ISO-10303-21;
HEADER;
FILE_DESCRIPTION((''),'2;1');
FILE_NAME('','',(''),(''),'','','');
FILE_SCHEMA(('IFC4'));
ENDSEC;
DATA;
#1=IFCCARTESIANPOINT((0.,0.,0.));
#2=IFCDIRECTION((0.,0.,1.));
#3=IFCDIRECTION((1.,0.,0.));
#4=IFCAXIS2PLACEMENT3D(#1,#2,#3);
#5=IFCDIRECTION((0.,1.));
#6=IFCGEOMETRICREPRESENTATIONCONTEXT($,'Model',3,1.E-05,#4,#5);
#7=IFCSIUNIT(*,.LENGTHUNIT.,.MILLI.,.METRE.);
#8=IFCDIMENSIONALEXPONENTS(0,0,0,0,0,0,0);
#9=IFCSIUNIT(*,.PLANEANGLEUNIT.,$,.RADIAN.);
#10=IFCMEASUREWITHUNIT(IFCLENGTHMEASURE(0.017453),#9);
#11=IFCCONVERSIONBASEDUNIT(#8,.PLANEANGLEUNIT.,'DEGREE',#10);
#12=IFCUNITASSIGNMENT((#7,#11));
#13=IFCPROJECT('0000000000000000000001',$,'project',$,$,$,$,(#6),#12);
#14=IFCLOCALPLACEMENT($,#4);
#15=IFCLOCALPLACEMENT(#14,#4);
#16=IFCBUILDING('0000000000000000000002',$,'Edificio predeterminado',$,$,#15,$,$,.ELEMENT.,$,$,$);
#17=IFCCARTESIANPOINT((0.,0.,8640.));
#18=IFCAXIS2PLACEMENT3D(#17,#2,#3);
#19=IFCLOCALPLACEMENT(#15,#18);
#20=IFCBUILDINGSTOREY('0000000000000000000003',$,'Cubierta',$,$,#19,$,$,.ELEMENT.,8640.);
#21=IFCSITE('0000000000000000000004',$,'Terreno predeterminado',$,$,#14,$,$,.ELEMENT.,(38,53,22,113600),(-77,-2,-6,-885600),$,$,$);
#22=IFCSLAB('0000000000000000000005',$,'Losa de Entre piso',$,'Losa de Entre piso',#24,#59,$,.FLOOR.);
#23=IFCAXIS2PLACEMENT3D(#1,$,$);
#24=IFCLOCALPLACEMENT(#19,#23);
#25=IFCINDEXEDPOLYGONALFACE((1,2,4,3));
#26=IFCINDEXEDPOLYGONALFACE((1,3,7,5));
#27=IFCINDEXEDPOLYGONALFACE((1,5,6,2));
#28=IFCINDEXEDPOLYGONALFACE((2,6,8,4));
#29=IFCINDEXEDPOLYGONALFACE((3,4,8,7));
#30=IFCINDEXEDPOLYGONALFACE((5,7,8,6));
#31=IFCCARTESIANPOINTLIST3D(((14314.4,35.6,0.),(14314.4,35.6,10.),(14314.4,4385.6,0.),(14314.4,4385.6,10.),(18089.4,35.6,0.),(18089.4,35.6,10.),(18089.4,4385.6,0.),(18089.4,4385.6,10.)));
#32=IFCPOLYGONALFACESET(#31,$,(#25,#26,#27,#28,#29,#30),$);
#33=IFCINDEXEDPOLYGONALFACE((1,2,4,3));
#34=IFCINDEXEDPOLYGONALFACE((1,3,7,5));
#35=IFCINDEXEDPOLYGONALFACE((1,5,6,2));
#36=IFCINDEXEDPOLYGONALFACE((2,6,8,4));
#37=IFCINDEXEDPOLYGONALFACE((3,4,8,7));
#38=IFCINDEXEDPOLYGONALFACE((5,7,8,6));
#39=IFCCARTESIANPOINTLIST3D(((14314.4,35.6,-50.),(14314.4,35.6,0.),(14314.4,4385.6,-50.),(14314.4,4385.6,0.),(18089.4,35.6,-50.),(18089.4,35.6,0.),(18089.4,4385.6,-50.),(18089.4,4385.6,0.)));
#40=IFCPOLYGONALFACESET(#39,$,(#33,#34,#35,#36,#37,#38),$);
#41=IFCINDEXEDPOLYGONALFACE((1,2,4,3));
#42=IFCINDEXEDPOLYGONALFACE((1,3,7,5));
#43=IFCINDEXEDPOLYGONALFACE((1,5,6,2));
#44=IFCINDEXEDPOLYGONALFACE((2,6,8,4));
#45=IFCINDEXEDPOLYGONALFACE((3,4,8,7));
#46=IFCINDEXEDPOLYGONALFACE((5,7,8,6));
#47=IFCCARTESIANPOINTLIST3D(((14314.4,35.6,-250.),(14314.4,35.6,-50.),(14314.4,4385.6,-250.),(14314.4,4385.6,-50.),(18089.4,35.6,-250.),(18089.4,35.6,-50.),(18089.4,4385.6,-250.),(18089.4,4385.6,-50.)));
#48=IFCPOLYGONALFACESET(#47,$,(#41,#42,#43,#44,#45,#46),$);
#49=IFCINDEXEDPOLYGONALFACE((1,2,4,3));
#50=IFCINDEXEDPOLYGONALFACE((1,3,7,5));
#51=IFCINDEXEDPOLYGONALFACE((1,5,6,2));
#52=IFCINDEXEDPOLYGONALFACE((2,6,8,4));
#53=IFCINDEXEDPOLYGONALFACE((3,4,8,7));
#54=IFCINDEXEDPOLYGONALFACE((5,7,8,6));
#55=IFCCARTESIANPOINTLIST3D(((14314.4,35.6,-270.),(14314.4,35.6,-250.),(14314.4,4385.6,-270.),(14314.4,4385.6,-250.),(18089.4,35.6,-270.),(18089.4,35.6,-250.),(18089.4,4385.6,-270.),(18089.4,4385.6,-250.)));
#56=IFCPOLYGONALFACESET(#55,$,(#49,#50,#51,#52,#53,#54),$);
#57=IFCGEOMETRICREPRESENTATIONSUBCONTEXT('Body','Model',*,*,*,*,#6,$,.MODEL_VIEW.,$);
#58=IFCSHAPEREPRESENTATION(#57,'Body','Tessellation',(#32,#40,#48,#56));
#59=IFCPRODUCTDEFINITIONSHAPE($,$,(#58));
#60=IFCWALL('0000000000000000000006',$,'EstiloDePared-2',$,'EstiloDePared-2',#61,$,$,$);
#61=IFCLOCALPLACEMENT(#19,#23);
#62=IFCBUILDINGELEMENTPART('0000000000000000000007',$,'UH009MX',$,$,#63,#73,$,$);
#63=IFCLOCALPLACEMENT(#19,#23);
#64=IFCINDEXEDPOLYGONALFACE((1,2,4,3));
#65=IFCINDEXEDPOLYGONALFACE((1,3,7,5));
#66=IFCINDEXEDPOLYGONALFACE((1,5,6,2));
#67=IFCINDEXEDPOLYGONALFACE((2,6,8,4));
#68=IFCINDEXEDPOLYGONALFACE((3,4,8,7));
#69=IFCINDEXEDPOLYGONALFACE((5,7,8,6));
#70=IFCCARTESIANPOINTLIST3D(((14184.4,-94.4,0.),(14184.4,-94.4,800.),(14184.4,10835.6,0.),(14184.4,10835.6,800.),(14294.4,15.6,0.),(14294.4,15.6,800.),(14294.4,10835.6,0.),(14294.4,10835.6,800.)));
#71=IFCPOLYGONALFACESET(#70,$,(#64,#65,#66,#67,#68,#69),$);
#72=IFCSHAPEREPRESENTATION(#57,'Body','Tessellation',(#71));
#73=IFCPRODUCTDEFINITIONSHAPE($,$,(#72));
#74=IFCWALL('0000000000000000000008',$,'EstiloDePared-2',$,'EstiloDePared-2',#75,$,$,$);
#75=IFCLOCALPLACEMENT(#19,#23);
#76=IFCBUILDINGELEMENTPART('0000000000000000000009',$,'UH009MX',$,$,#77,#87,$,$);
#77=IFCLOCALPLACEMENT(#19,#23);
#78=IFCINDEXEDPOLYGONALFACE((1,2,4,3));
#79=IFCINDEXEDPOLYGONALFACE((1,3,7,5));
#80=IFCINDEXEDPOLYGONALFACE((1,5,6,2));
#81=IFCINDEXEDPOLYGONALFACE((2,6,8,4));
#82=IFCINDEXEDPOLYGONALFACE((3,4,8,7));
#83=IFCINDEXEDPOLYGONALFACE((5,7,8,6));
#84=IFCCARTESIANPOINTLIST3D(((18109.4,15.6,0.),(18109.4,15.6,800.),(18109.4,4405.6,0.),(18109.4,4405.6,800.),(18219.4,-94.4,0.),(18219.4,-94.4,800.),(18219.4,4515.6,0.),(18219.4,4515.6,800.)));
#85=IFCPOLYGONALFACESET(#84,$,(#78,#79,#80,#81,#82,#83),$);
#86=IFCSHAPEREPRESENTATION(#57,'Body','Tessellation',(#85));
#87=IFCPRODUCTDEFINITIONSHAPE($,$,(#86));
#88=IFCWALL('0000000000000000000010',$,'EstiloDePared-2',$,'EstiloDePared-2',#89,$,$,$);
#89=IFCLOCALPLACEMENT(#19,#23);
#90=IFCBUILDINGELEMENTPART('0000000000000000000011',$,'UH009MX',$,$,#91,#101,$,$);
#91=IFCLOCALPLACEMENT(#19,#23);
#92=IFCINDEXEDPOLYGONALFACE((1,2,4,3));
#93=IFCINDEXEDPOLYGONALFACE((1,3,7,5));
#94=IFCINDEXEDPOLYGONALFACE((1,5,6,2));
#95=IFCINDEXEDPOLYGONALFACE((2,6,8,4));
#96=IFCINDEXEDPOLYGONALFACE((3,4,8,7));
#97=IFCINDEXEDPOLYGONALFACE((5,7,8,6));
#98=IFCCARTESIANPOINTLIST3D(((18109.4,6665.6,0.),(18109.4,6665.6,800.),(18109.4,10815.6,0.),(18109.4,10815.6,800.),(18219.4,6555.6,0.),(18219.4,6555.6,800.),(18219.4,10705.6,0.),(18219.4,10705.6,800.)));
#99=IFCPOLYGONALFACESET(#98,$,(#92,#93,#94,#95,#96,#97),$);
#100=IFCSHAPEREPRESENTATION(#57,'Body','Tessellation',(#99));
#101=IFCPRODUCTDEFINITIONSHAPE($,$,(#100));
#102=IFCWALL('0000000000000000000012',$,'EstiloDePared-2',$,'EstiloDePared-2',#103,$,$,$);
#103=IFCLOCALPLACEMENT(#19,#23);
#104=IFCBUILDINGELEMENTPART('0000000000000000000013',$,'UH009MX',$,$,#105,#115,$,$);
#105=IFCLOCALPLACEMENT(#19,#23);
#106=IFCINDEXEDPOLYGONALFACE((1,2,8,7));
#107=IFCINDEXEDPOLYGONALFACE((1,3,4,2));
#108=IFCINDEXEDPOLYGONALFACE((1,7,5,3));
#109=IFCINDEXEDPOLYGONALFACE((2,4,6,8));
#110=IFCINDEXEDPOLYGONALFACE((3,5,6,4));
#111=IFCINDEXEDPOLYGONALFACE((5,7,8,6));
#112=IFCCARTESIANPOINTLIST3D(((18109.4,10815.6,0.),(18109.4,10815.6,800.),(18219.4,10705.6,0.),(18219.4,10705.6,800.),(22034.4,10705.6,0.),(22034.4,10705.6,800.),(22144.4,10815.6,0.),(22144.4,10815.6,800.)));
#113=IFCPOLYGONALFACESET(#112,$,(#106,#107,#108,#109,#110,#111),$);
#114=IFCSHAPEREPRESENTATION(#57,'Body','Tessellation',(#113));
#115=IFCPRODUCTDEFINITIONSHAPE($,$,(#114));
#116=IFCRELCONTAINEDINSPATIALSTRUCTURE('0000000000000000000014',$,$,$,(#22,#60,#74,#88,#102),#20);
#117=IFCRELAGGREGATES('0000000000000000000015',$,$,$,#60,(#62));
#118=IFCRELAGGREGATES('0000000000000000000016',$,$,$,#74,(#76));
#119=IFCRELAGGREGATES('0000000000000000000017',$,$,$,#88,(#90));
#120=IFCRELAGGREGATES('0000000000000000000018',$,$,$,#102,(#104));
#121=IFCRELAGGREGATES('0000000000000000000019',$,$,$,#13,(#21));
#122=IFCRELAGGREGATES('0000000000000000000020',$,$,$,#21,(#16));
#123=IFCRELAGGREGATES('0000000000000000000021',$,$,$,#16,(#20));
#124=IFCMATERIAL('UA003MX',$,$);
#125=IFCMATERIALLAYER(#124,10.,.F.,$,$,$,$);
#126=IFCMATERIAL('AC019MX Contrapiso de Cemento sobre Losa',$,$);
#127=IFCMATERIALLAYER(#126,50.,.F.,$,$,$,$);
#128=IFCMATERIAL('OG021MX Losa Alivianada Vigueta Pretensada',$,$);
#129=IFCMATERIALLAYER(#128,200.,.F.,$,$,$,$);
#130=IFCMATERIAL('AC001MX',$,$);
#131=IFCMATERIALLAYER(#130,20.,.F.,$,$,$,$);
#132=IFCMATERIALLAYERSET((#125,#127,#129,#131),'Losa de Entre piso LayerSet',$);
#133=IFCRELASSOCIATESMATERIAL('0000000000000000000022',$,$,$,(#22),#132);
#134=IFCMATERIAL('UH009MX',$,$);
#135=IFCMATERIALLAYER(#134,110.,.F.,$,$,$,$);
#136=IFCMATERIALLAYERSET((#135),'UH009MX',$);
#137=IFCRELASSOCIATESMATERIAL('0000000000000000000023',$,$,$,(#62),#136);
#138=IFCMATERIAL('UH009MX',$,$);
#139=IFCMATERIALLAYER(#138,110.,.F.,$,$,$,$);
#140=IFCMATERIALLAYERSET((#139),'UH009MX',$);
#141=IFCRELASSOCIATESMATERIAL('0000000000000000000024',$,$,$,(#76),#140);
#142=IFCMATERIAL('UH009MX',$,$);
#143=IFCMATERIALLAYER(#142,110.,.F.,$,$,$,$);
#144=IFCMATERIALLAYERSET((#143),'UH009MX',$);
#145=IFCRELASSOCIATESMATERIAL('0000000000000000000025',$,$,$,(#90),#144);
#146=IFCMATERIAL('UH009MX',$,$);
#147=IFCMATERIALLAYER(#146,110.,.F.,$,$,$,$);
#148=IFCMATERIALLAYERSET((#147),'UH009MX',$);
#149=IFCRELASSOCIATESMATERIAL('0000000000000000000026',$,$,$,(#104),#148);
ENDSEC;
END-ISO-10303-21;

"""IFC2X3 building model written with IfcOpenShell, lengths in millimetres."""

from ifc_helpers import new_model, entity, si_unit, converted_unit, direction, frame, origin_with_axes, place, context, subcontext, project, spatial, polyline, outline, extrude, material, layer, layer_set, layer_usage, element, aggregate, save


model = new_model("IFC2X3")

# Units and contexts
model_context = context("Model", 3, precision=1e-05, world=origin_with_axes(), true_north=direction((0.0, 1.0)))
body_context = subcontext(model_context, "Body", "Model", "MODEL_VIEW")
ifc_project = project(units=[si_unit("LENGTHUNIT", "METRE", prefix="MILLI"), converted_unit("PLANEANGLEUNIT", "DEGREE", entity("IfcLengthMeasure", 0.017453), si_unit("PLANEANGLEUNIT", "RADIAN"), dimensions=[0, 0, 0, 0, 0, 0, 0])], contexts=[model_context])

# Site, building, storey
site_placement = place(None, origin_with_axes())
site = spatial("IfcSite", under=ifc_project, at=site_placement, Name="Terreno predeterminado", CompositionType="ELEMENT", RefLatitude=(38, 53, 22, 113600), RefLongitude=(-77, -2, -6, -885600))
building_placement = place(site_placement, origin_with_axes())
building = spatial("IfcBuilding", under=site, at=building_placement, Name="Edificio predeterminado", CompositionType="ELEMENT")
storey_placement = place(building_placement, frame((0.0, 0.0, 8640.0), z_axis=(0.0, 0.0, 1.0), x_axis=(1.0, 0.0, 0.0)))
storey = spatial("IfcBuildingStorey", under=building, at=storey_placement, Name="Cubierta", CompositionType="ELEMENT", Elevation=8640.0)

# Slab
ifc_material_1 = material(Name="UA003MX")
ifc_layer_1 = layer(ifc_material_1, 10.0, ventilated=False)
ifc_material_2 = material(Name="AC019MX Contrapiso de Cemento sobre Losa")
ifc_layer_2 = layer(ifc_material_2, 50.0, ventilated=False)
ifc_material_3 = material(Name="OG021MX Losa Alivianada Vigueta Pretensada")
ifc_layer_3 = layer(ifc_material_3, 200.0, ventilated=False)
ifc_material_4 = material(Name="AC001MX")
ifc_layer_4 = layer(ifc_material_4, 20.0, ventilated=False)
ifc_layer_set_1 = layer_set([ifc_layer_1, ifc_layer_2, ifc_layer_3, ifc_layer_4], Name="Losa de Entre piso LayerSet")
ifc_layer_usage_1 = layer_usage(ifc_layer_set_1, "AXIS3", "NEGATIVE", 0.0)
slab_1_placement = place(storey_placement, frame((0.0, 0.0, -8640.0), z_axis=(0.0, 0.0, 1.0), x_axis=(1.0, 0.0, 0.0)))
element("IfcSlab", 1, at=slab_1_placement, inside=storey, material=ifc_layer_usage_1, Name="Losa de Entre piso", ObjectType="Losa de Entre piso", PredefinedType="FLOOR", context=body_context, shape_type="SweptSolid", body=[
    extrude(outline(polyline([(0.0, 4350.0), (3775.0, 4350.0), (3775.0, 0.0), (0.0, 0.0), (0.0, 4350.0)])), frame((18089.4, 35.6, 8640.0), z_axis=(0.0, 0.0, -1.0), x_axis=(-1.0, 0.0, 0.0)), (0.0, 0.0, -1.0), 10.0),
    extrude(outline(polyline([(0.0, 4350.0), (3775.0, 4350.0), (3775.0, 0.0), (0.0, 0.0), (0.0, 4350.0)])), frame((18089.4, 35.6, 8590.0), z_axis=(0.0, 0.0, -1.0), x_axis=(-1.0, 0.0, 0.0)), (0.0, 0.0, -1.0), 50.0),
    extrude(outline(polyline([(0.0, 4350.0), (3775.0, 4350.0), (3775.0, 0.0), (0.0, 0.0), (0.0, 4350.0)])), frame((18089.4, 35.6, 8390.0), z_axis=(0.0, 0.0, -1.0), x_axis=(-1.0, 0.0, 0.0)), (0.0, 0.0, -1.0), 200.0),
    extrude(outline(polyline([(0.0, 4350.0), (3775.0, 4350.0), (3775.0, 0.0), (0.0, 0.0), (0.0, 4350.0)])), frame((18089.4, 35.6, 8370.0), z_axis=(0.0, 0.0, -1.0), x_axis=(-1.0, 0.0, 0.0)), (0.0, 0.0, -1.0), 20.0),
])

# Walls, building element parts
wall_1_placement = place(storey_placement, frame((14239.4, -39.4, 0.0), z_axis=(0.0, 0.0, 1.0), x_axis=(0.0, 1.0, 0.0)))
wall_1 = element("IfcWall", 2, at=wall_1_placement, inside=storey, Name="EstiloDePared-2", ObjectType="EstiloDePared-2")
ifc_material_5 = material(Name="UH009MX")
ifc_layer_5 = layer(ifc_material_5, 110.0, ventilated=False)
ifc_layer_set_2 = layer_set([ifc_layer_5], Name="UH009MX")
ifc_layer_usage_2 = layer_usage(ifc_layer_set_2, "AXIS2", "NEGATIVE", -55.0)
building_element_part_1_placement = place(wall_1_placement, origin_with_axes())
building_element_part_1 = element("IfcBuildingElementPart", 3, at=building_element_part_1_placement, material=ifc_layer_usage_2, Name="UH009MX", context=body_context, shape_type="SweptSolid", body=[
    extrude(outline(polyline([(10875.0, 55.0), (10875.0, -55.0), (55.0, -55.0), (-55.0, 55.0), (10875.0, 55.0)])), origin_with_axes(), (0.0, 0.0, 1.0), 800.0),
])
aggregate(wall_1, [building_element_part_1])
wall_2_placement = place(storey_placement, frame((18164.4, -39.4, 0.0), z_axis=(0.0, 0.0, 1.0), x_axis=(0.0, 1.0, 0.0)))
wall_2 = element("IfcWall", 4, at=wall_2_placement, inside=storey, Name="EstiloDePared-2", ObjectType="EstiloDePared-2")
ifc_material_6 = material(Name="UH009MX")
ifc_layer_6 = layer(ifc_material_6, 110.0, ventilated=False)
ifc_layer_set_3 = layer_set([ifc_layer_6], Name="UH009MX")
ifc_layer_usage_3 = layer_usage(ifc_layer_set_3, "AXIS2", "NEGATIVE", -55.0)
building_element_part_2_placement = place(wall_2_placement, origin_with_axes())
building_element_part_2 = element("IfcBuildingElementPart", 5, at=building_element_part_2_placement, material=ifc_layer_usage_3, Name="UH009MX", context=body_context, shape_type="SweptSolid", body=[
    extrude(outline(polyline([(4445.0, 55.0), (4555.0, -55.0), (-55.0, -55.0), (55.0, 55.0), (4445.0, 55.0)])), origin_with_axes(), (0.0, 0.0, 1.0), 800.0),
])
aggregate(wall_2, [building_element_part_2])
wall_3_placement = place(storey_placement, frame((18164.4, 6610.6, 0.0), z_axis=(0.0, 0.0, 1.0), x_axis=(0.0, 1.0, 0.0)))
wall_3 = element("IfcWall", 6, at=wall_3_placement, inside=storey, Name="EstiloDePared-2", ObjectType="EstiloDePared-2")
ifc_material_7 = material(Name="UH009MX")
ifc_layer_7 = layer(ifc_material_7, 110.0, ventilated=False)
ifc_layer_set_4 = layer_set([ifc_layer_7], Name="UH009MX")
ifc_layer_usage_4 = layer_usage(ifc_layer_set_4, "AXIS2", "NEGATIVE", -55.0)
building_element_part_3_placement = place(wall_3_placement, origin_with_axes())
building_element_part_3 = element("IfcBuildingElementPart", 7, at=building_element_part_3_placement, material=ifc_layer_usage_4, Name="UH009MX", context=body_context, shape_type="SweptSolid", body=[
    extrude(outline(polyline([(4205.0, 55.0), (4095.0, -55.0), (-55.0, -55.0), (55.0, 55.0), (4205.0, 55.0)])), origin_with_axes(), (0.0, 0.0, 1.0), 800.0),
])
aggregate(wall_3, [building_element_part_3])
wall_4_placement = place(storey_placement, frame((18164.4, 10760.6, 0.0), z_axis=(0.0, 0.0, 1.0), x_axis=(1.0, 0.0, 0.0)))
wall_4 = element("IfcWall", 8, at=wall_4_placement, inside=storey, Name="EstiloDePared-2", ObjectType="EstiloDePared-2")
ifc_material_8 = material(Name="UH009MX")
ifc_layer_8 = layer(ifc_material_8, 110.0, ventilated=False)
ifc_layer_set_5 = layer_set([ifc_layer_8], Name="UH009MX")
ifc_layer_usage_5 = layer_usage(ifc_layer_set_5, "AXIS2", "NEGATIVE", -55.0)
building_element_part_4_placement = place(wall_4_placement, origin_with_axes())
building_element_part_4 = element("IfcBuildingElementPart", 9, at=building_element_part_4_placement, material=ifc_layer_usage_5, Name="UH009MX", context=body_context, shape_type="SweptSolid", body=[
    extrude(outline(polyline([(3980.0, 55.0), (3870.0, -55.0), (55.0, -55.0), (-55.0, 55.0), (3980.0, 55.0)])), origin_with_axes(), (0.0, 0.0, 1.0), 800.0),
])
aggregate(wall_4, [building_element_part_4])

save(model, "model.ifc")
